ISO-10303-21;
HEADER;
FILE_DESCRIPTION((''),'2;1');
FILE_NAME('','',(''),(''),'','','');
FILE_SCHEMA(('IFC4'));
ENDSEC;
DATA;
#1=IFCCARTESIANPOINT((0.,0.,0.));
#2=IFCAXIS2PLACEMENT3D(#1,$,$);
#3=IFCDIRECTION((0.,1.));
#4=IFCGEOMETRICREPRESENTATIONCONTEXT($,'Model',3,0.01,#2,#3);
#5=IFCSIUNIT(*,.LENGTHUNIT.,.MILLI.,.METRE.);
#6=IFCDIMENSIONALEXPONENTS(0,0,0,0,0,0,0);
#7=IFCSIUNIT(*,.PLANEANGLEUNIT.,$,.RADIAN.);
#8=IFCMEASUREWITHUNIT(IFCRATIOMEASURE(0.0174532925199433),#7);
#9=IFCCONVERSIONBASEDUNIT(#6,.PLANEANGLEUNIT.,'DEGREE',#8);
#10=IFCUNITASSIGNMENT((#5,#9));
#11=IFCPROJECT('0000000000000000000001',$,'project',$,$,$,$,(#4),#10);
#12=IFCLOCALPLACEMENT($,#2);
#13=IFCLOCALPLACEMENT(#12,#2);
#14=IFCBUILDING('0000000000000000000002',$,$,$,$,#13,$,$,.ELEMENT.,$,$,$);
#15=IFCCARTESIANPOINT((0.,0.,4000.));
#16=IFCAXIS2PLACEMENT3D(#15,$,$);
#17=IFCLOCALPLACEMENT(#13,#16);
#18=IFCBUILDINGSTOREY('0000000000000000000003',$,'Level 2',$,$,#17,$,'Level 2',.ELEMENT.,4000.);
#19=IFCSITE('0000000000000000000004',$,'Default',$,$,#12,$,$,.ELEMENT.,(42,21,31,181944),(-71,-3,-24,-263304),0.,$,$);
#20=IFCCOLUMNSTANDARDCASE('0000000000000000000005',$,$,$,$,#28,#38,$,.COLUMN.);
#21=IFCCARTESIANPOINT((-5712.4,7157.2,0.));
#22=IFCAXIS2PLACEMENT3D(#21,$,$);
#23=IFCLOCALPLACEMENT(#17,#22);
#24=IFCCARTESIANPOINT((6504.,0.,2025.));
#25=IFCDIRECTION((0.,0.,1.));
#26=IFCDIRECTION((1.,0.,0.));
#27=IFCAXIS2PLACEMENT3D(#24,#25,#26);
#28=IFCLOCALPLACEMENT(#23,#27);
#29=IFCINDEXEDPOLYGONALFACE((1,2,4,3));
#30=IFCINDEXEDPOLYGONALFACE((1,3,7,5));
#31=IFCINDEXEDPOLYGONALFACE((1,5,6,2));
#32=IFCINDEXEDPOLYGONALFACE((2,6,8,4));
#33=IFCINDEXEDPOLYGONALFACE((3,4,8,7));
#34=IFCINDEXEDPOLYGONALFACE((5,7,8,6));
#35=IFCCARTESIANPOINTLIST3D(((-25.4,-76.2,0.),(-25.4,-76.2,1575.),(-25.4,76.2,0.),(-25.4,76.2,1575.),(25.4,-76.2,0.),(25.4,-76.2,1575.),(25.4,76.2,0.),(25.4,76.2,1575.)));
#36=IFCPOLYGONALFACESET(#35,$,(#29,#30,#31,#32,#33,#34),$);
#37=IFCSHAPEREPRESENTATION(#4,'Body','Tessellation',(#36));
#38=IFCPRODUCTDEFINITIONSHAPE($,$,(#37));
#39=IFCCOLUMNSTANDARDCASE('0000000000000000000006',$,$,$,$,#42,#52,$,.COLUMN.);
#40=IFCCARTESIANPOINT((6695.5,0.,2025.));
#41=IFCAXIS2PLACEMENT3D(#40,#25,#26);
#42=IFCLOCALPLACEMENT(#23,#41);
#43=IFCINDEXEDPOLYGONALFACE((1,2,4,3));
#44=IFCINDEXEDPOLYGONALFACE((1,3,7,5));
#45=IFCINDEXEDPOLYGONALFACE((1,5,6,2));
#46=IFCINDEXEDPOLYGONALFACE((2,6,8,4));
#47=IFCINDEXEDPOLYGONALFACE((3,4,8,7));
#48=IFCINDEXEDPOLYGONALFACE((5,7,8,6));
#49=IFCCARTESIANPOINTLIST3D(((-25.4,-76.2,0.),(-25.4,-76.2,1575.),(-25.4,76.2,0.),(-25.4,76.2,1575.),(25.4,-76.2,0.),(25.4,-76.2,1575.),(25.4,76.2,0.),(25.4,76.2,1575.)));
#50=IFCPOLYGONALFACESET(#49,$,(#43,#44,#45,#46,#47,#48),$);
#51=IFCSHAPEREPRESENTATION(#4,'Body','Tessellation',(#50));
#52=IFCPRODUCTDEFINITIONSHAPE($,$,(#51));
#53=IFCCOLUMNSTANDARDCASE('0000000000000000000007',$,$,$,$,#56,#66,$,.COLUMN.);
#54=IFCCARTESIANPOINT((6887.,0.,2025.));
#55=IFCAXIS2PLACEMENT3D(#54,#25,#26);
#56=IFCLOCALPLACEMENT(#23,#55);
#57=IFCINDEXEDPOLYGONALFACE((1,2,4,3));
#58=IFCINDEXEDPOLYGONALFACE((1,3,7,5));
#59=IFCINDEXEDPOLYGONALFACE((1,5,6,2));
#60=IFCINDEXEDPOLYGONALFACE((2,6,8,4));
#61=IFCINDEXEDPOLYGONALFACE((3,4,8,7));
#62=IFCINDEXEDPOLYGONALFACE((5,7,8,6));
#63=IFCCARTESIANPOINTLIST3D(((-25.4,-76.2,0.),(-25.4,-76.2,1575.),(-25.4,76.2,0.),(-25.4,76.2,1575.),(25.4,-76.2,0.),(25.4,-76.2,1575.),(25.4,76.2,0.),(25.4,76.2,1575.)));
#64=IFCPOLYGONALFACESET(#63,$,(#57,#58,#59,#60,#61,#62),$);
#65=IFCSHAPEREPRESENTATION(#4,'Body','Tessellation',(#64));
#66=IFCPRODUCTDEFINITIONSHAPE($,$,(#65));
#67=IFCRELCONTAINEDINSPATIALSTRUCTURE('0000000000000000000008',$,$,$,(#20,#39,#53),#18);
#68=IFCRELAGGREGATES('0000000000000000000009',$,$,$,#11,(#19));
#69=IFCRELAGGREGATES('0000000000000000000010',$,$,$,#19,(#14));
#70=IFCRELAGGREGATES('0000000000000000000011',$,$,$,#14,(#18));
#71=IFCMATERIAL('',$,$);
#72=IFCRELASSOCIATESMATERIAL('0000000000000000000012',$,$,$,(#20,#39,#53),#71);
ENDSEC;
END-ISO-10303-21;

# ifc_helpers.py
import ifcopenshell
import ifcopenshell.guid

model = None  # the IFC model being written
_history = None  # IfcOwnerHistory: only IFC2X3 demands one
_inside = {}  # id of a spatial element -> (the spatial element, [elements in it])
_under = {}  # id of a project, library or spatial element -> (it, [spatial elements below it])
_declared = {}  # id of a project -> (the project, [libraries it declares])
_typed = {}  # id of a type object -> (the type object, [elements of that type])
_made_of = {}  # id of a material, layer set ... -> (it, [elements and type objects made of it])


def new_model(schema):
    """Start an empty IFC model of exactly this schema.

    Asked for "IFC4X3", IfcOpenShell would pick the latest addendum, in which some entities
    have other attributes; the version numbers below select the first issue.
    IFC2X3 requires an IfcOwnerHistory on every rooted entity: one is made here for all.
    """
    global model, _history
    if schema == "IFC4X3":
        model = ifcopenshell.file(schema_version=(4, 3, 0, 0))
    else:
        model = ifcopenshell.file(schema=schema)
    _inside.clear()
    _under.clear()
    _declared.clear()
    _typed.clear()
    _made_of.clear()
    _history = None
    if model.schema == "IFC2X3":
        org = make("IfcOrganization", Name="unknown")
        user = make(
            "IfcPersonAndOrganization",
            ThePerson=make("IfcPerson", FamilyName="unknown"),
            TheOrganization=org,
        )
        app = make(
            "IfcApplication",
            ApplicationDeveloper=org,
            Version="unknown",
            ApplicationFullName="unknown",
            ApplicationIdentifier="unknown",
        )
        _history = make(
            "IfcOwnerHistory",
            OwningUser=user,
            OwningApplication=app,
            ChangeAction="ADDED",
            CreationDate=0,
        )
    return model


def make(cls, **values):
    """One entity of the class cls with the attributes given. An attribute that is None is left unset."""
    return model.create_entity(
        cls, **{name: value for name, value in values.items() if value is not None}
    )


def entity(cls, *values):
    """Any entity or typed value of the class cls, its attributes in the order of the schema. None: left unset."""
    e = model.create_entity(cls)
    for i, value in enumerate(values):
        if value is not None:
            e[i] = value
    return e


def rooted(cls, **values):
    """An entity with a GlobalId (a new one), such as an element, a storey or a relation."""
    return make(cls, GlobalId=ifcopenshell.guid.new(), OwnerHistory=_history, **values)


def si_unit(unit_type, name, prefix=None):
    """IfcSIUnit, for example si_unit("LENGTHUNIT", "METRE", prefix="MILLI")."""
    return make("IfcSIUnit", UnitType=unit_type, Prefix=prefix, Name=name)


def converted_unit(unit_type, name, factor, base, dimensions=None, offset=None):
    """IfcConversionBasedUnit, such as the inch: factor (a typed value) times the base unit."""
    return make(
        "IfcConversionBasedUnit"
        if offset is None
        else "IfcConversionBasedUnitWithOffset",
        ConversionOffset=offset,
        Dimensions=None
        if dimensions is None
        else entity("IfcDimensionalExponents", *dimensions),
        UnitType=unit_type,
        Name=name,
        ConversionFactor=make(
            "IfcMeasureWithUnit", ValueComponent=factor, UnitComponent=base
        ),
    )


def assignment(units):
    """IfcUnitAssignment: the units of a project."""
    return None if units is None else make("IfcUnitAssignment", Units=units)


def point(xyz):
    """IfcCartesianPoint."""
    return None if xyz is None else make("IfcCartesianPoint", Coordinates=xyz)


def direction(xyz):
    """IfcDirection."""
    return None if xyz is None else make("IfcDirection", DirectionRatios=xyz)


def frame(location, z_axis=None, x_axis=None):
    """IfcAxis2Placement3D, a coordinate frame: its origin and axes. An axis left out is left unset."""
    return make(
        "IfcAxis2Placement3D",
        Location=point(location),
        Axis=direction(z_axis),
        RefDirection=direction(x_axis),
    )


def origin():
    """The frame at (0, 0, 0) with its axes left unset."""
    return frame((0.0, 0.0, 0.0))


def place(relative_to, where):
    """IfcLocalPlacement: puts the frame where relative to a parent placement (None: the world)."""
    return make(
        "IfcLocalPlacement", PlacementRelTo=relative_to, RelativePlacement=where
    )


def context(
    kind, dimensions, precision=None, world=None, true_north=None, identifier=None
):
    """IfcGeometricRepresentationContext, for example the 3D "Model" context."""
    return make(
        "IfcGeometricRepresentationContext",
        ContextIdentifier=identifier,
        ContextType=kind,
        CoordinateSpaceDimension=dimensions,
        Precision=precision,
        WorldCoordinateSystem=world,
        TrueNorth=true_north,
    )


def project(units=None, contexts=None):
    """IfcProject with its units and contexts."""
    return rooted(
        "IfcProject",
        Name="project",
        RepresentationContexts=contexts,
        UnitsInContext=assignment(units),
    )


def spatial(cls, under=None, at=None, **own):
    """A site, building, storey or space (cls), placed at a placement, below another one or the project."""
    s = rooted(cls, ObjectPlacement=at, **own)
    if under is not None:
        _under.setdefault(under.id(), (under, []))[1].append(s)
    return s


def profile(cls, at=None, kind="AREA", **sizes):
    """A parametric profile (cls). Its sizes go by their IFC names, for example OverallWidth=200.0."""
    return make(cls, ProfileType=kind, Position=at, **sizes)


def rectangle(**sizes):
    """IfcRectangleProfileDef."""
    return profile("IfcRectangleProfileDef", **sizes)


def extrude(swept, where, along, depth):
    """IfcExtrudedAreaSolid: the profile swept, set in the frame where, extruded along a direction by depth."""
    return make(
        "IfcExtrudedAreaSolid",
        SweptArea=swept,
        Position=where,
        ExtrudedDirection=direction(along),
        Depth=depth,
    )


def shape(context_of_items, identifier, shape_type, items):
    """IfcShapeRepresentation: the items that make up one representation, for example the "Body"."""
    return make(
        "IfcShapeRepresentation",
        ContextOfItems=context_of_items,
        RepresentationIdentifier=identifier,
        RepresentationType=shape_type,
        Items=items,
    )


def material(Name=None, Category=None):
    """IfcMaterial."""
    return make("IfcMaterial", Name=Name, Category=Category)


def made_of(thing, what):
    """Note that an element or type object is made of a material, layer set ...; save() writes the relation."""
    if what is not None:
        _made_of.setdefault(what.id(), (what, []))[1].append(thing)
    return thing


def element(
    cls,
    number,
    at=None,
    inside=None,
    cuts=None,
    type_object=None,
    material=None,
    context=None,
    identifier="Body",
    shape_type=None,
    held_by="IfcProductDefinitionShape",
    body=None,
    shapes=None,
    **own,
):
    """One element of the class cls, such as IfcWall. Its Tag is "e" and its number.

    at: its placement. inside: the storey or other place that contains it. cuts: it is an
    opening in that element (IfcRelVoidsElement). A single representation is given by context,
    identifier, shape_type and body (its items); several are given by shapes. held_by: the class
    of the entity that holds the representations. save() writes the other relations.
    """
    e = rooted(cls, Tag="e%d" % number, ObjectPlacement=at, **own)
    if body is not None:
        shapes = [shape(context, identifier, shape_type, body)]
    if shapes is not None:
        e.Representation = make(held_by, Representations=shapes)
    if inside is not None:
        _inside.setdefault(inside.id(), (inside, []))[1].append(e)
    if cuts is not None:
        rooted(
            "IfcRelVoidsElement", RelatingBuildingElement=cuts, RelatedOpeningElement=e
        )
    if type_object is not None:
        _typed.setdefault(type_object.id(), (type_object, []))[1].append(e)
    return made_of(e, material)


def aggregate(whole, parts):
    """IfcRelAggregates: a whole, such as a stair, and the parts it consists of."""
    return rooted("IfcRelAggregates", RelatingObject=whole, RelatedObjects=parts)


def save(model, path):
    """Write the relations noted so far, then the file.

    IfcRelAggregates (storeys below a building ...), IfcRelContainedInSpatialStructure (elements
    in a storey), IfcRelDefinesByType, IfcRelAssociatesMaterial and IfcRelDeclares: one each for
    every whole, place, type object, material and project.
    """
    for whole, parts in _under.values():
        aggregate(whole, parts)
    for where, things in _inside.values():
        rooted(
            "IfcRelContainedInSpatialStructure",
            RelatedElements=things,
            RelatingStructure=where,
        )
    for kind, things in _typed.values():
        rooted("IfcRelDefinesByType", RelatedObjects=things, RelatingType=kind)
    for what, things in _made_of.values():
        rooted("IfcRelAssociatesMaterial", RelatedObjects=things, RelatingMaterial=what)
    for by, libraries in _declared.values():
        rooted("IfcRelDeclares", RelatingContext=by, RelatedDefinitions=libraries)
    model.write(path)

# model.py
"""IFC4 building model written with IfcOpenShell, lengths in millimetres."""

from ifc_helpers import new_model, entity, si_unit, converted_unit, direction, frame, origin, place, context, project, spatial, rectangle, extrude, material, element, save


model = new_model("IFC4")

# Units and contexts
model_context = context("Model", 3, precision=0.01, world=origin(), true_north=direction((0.0, 1.0)))
ifc_project = project(units=[si_unit("LENGTHUNIT", "METRE", prefix="MILLI"), converted_unit("PLANEANGLEUNIT", "DEGREE", entity("IfcRatioMeasure", 0.0174532925199433), si_unit("PLANEANGLEUNIT", "RADIAN"), dimensions=[0, 0, 0, 0, 0, 0, 0])], contexts=[model_context])

# Site, building, storey
site_placement = place(None, origin())
site = spatial("IfcSite", under=ifc_project, at=site_placement, Name="Default", CompositionType="ELEMENT", RefLatitude=(42, 21, 31, 181944), RefLongitude=(-71, -3, -24, -263304), RefElevation=0.0)
building_placement = place(site_placement, origin())
building = spatial("IfcBuilding", under=site, at=building_placement, CompositionType="ELEMENT")
storey_placement = place(building_placement, frame((0.0, 0.0, 4000.0)))
storey = spatial("IfcBuildingStorey", under=building, at=storey_placement, Name="Level 2", LongName="Level 2", CompositionType="ELEMENT", Elevation=4000.0)

# Columns
ifc_material_1 = material(Name="")
placement_1 = place(storey_placement, frame((-5712.4, 7157.2, 0.0)))
for number, where, z_axis, x_axis in (
    (1, (6504.0, 0.0, 2025.0), (0.0, 0.0, 1.0), (1.0, 0.0, 0.0)),
    (2, (6695.5, 0.0, 2025.0), (0.0, 0.0, 1.0), (1.0, 0.0, 0.0)),
    (3, (6887.0, 0.0, 2025.0), (0.0, 0.0, 1.0), (1.0, 0.0, 0.0)),
):
    element("IfcColumnStandardCase", number, at=place(placement_1, frame(where, z_axis=z_axis, x_axis=x_axis)), inside=storey, material=ifc_material_1, PredefinedType="COLUMN", context=model_context, shape_type="SweptSolid", body=[
        extrude(rectangle(XDim=50.8, YDim=152.4), origin(), (0.0, 0.0, 1.0), 1575.0),
    ])

save(model, "model.ifc")
